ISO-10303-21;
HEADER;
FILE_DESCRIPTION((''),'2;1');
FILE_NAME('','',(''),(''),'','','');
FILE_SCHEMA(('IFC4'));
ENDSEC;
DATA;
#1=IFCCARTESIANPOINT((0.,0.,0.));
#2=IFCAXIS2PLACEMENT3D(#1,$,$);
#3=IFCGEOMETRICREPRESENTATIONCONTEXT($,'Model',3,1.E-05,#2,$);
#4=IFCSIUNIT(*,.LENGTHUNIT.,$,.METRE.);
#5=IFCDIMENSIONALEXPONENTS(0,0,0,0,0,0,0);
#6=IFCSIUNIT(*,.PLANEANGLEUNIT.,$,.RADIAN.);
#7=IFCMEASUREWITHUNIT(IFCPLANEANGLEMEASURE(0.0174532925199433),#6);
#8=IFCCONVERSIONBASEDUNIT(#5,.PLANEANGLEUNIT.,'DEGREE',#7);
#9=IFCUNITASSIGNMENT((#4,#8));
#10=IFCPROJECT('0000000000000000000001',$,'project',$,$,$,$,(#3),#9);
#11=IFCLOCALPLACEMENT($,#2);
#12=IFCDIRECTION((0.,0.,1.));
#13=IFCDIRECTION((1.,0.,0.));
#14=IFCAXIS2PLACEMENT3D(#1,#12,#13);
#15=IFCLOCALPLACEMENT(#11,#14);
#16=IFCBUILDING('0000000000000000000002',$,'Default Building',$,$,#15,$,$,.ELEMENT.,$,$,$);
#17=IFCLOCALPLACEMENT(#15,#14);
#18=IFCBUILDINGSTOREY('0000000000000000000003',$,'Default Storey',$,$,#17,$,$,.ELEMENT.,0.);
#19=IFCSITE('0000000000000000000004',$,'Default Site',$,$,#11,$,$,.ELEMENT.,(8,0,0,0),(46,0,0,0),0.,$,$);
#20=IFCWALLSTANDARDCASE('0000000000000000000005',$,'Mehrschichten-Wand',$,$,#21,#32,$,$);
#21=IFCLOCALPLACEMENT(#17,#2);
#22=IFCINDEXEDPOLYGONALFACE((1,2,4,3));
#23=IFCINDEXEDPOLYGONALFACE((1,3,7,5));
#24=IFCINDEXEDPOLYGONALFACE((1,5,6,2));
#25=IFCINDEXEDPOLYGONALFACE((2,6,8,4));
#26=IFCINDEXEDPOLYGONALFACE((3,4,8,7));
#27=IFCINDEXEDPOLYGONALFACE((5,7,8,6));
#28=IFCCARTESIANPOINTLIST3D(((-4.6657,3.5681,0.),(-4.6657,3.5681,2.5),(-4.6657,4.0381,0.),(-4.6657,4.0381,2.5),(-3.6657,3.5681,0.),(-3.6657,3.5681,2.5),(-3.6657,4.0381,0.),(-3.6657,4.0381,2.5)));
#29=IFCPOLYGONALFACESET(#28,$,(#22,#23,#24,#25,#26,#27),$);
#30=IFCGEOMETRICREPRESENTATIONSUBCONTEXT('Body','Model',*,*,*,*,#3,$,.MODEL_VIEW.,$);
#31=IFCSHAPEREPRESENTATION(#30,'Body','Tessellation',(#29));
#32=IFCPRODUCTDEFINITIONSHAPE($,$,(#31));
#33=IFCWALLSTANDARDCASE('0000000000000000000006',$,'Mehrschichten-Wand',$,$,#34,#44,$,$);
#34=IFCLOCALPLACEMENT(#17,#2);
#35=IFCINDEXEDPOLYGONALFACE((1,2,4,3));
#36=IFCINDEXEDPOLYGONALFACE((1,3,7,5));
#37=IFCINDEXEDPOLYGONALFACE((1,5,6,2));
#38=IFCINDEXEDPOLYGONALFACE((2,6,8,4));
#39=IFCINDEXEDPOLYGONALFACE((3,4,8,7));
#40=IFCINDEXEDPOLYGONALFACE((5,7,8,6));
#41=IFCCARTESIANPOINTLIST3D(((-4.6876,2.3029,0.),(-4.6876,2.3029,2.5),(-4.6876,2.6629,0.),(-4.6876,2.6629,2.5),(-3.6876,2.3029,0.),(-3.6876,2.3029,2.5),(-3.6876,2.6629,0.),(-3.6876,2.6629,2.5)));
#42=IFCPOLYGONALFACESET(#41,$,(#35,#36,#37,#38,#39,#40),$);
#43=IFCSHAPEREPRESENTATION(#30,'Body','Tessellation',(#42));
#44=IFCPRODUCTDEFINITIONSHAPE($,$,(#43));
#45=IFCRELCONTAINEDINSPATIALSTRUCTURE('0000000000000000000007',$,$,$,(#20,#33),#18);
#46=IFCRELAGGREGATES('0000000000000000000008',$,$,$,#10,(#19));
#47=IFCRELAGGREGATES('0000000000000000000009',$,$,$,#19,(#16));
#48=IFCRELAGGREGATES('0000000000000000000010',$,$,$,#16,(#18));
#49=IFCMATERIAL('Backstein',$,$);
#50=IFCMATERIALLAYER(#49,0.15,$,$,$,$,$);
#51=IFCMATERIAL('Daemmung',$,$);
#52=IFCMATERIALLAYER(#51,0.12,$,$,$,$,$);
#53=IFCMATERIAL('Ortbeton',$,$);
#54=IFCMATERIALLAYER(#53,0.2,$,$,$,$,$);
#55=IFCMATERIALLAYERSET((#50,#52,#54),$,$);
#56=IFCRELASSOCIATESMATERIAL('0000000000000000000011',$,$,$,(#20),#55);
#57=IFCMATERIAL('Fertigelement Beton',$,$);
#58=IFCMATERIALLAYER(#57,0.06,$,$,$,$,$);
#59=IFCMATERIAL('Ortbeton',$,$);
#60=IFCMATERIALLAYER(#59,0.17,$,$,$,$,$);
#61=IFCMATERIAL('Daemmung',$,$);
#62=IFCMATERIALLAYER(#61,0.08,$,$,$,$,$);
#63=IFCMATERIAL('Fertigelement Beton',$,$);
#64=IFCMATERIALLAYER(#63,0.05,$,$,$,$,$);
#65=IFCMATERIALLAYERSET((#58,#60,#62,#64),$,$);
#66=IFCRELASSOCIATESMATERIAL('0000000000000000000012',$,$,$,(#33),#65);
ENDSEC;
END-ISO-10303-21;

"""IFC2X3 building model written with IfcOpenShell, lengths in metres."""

from ifc_helpers import new_model, entity, si_unit, converted_unit, frame, frame_2d, origin, origin_with_axes, place, context, subcontext, project, spatial, rectangle, extrude, material, layer, layer_set, layer_usage, element, save


model = new_model("IFC2X3")

# Units and contexts
model_context = context("Model", 3, precision=1e-05, world=origin())
body_context = subcontext(model_context, "Body", "Model", "MODEL_VIEW")
ifc_project = project(units=[si_unit("LENGTHUNIT", "METRE"), converted_unit("PLANEANGLEUNIT", "DEGREE", entity("IfcPlaneAngleMeasure", 0.0174532925199433), si_unit("PLANEANGLEUNIT", "RADIAN"), dimensions=[0, 0, 0, 0, 0, 0, 0])], contexts=[model_context])

# Site, building, storey
site_placement = place(None, origin())
site = spatial("IfcSite", under=ifc_project, at=site_placement, Name="Default Site", CompositionType="ELEMENT", RefLatitude=(8, 0, 0, 0), RefLongitude=(46, 0, 0, 0), RefElevation=0.0)
building_placement = place(site_placement, origin_with_axes())
building = spatial("IfcBuilding", under=site, at=building_placement, Name="Default Building", CompositionType="ELEMENT")
storey_placement = place(building_placement, origin_with_axes())
storey = spatial("IfcBuildingStorey", under=building, at=storey_placement, Name="Default Storey", CompositionType="ELEMENT", Elevation=0.0)

# Walls
ifc_material_1 = material(Name="Backstein")
ifc_layer_1 = layer(ifc_material_1, 0.15)
ifc_material_2 = material(Name="Daemmung")
ifc_layer_2 = layer(ifc_material_2, 0.12)
ifc_material_3 = material(Name="Ortbeton")
ifc_layer_3 = layer(ifc_material_3, 0.2)
ifc_layer_set_1 = layer_set([ifc_layer_1, ifc_layer_2, ifc_layer_3])
ifc_layer_usage_1 = layer_usage(ifc_layer_set_1, "AXIS2", "POSITIVE", -0.47)
wall_1_placement = place(storey_placement, frame((-4.6657, 3.5681, 0.0), z_axis=(0.0, 0.0, 1.0), x_axis=(1.0, 0.0, 0.0)))
element("IfcWallStandardCase", 1, at=wall_1_placement, inside=storey, material=ifc_layer_usage_1, Name="Mehrschichten-Wand", context=body_context, shape_type="SweptSolid", body=[
    extrude(rectangle(XDim=1.0, YDim=0.47, at=frame_2d((0.5, 0.235), x_axis=(1.0, 0.0))), origin_with_axes(), (0.0, 0.0, 1.0), 2.5),
])
ifc_material_4 = material(Name="Fertigelement Beton")
ifc_layer_4 = layer(ifc_material_4, 0.06)
ifc_material_5 = material(Name="Ortbeton")
ifc_layer_5 = layer(ifc_material_5, 0.17)
ifc_material_6 = material(Name="Daemmung")
ifc_layer_6 = layer(ifc_material_6, 0.08)
ifc_material_7 = material(Name="Fertigelement Beton")
ifc_layer_7 = layer(ifc_material_7, 0.05)
ifc_layer_set_2 = layer_set([ifc_layer_4, ifc_layer_5, ifc_layer_6, ifc_layer_7])
ifc_layer_usage_2 = layer_usage(ifc_layer_set_2, "AXIS2", "POSITIVE", 0.0)
wall_2_placement = place(storey_placement, frame((-4.6876, 2.3029, 0.0), z_axis=(0.0, 0.0, 1.0), x_axis=(1.0, 0.0, 0.0)))
element("IfcWallStandardCase", 2, at=wall_2_placement, inside=storey, material=ifc_layer_usage_2, Name="Mehrschichten-Wand", context=body_context, shape_type="SweptSolid", body=[
    extrude(rectangle(XDim=1.0, YDim=0.36, at=frame_2d((0.5, 0.18), x_axis=(1.0, 0.0))), origin_with_axes(), (0.0, 0.0, 1.0), 2.5),
])

save(model, "model.ifc")
